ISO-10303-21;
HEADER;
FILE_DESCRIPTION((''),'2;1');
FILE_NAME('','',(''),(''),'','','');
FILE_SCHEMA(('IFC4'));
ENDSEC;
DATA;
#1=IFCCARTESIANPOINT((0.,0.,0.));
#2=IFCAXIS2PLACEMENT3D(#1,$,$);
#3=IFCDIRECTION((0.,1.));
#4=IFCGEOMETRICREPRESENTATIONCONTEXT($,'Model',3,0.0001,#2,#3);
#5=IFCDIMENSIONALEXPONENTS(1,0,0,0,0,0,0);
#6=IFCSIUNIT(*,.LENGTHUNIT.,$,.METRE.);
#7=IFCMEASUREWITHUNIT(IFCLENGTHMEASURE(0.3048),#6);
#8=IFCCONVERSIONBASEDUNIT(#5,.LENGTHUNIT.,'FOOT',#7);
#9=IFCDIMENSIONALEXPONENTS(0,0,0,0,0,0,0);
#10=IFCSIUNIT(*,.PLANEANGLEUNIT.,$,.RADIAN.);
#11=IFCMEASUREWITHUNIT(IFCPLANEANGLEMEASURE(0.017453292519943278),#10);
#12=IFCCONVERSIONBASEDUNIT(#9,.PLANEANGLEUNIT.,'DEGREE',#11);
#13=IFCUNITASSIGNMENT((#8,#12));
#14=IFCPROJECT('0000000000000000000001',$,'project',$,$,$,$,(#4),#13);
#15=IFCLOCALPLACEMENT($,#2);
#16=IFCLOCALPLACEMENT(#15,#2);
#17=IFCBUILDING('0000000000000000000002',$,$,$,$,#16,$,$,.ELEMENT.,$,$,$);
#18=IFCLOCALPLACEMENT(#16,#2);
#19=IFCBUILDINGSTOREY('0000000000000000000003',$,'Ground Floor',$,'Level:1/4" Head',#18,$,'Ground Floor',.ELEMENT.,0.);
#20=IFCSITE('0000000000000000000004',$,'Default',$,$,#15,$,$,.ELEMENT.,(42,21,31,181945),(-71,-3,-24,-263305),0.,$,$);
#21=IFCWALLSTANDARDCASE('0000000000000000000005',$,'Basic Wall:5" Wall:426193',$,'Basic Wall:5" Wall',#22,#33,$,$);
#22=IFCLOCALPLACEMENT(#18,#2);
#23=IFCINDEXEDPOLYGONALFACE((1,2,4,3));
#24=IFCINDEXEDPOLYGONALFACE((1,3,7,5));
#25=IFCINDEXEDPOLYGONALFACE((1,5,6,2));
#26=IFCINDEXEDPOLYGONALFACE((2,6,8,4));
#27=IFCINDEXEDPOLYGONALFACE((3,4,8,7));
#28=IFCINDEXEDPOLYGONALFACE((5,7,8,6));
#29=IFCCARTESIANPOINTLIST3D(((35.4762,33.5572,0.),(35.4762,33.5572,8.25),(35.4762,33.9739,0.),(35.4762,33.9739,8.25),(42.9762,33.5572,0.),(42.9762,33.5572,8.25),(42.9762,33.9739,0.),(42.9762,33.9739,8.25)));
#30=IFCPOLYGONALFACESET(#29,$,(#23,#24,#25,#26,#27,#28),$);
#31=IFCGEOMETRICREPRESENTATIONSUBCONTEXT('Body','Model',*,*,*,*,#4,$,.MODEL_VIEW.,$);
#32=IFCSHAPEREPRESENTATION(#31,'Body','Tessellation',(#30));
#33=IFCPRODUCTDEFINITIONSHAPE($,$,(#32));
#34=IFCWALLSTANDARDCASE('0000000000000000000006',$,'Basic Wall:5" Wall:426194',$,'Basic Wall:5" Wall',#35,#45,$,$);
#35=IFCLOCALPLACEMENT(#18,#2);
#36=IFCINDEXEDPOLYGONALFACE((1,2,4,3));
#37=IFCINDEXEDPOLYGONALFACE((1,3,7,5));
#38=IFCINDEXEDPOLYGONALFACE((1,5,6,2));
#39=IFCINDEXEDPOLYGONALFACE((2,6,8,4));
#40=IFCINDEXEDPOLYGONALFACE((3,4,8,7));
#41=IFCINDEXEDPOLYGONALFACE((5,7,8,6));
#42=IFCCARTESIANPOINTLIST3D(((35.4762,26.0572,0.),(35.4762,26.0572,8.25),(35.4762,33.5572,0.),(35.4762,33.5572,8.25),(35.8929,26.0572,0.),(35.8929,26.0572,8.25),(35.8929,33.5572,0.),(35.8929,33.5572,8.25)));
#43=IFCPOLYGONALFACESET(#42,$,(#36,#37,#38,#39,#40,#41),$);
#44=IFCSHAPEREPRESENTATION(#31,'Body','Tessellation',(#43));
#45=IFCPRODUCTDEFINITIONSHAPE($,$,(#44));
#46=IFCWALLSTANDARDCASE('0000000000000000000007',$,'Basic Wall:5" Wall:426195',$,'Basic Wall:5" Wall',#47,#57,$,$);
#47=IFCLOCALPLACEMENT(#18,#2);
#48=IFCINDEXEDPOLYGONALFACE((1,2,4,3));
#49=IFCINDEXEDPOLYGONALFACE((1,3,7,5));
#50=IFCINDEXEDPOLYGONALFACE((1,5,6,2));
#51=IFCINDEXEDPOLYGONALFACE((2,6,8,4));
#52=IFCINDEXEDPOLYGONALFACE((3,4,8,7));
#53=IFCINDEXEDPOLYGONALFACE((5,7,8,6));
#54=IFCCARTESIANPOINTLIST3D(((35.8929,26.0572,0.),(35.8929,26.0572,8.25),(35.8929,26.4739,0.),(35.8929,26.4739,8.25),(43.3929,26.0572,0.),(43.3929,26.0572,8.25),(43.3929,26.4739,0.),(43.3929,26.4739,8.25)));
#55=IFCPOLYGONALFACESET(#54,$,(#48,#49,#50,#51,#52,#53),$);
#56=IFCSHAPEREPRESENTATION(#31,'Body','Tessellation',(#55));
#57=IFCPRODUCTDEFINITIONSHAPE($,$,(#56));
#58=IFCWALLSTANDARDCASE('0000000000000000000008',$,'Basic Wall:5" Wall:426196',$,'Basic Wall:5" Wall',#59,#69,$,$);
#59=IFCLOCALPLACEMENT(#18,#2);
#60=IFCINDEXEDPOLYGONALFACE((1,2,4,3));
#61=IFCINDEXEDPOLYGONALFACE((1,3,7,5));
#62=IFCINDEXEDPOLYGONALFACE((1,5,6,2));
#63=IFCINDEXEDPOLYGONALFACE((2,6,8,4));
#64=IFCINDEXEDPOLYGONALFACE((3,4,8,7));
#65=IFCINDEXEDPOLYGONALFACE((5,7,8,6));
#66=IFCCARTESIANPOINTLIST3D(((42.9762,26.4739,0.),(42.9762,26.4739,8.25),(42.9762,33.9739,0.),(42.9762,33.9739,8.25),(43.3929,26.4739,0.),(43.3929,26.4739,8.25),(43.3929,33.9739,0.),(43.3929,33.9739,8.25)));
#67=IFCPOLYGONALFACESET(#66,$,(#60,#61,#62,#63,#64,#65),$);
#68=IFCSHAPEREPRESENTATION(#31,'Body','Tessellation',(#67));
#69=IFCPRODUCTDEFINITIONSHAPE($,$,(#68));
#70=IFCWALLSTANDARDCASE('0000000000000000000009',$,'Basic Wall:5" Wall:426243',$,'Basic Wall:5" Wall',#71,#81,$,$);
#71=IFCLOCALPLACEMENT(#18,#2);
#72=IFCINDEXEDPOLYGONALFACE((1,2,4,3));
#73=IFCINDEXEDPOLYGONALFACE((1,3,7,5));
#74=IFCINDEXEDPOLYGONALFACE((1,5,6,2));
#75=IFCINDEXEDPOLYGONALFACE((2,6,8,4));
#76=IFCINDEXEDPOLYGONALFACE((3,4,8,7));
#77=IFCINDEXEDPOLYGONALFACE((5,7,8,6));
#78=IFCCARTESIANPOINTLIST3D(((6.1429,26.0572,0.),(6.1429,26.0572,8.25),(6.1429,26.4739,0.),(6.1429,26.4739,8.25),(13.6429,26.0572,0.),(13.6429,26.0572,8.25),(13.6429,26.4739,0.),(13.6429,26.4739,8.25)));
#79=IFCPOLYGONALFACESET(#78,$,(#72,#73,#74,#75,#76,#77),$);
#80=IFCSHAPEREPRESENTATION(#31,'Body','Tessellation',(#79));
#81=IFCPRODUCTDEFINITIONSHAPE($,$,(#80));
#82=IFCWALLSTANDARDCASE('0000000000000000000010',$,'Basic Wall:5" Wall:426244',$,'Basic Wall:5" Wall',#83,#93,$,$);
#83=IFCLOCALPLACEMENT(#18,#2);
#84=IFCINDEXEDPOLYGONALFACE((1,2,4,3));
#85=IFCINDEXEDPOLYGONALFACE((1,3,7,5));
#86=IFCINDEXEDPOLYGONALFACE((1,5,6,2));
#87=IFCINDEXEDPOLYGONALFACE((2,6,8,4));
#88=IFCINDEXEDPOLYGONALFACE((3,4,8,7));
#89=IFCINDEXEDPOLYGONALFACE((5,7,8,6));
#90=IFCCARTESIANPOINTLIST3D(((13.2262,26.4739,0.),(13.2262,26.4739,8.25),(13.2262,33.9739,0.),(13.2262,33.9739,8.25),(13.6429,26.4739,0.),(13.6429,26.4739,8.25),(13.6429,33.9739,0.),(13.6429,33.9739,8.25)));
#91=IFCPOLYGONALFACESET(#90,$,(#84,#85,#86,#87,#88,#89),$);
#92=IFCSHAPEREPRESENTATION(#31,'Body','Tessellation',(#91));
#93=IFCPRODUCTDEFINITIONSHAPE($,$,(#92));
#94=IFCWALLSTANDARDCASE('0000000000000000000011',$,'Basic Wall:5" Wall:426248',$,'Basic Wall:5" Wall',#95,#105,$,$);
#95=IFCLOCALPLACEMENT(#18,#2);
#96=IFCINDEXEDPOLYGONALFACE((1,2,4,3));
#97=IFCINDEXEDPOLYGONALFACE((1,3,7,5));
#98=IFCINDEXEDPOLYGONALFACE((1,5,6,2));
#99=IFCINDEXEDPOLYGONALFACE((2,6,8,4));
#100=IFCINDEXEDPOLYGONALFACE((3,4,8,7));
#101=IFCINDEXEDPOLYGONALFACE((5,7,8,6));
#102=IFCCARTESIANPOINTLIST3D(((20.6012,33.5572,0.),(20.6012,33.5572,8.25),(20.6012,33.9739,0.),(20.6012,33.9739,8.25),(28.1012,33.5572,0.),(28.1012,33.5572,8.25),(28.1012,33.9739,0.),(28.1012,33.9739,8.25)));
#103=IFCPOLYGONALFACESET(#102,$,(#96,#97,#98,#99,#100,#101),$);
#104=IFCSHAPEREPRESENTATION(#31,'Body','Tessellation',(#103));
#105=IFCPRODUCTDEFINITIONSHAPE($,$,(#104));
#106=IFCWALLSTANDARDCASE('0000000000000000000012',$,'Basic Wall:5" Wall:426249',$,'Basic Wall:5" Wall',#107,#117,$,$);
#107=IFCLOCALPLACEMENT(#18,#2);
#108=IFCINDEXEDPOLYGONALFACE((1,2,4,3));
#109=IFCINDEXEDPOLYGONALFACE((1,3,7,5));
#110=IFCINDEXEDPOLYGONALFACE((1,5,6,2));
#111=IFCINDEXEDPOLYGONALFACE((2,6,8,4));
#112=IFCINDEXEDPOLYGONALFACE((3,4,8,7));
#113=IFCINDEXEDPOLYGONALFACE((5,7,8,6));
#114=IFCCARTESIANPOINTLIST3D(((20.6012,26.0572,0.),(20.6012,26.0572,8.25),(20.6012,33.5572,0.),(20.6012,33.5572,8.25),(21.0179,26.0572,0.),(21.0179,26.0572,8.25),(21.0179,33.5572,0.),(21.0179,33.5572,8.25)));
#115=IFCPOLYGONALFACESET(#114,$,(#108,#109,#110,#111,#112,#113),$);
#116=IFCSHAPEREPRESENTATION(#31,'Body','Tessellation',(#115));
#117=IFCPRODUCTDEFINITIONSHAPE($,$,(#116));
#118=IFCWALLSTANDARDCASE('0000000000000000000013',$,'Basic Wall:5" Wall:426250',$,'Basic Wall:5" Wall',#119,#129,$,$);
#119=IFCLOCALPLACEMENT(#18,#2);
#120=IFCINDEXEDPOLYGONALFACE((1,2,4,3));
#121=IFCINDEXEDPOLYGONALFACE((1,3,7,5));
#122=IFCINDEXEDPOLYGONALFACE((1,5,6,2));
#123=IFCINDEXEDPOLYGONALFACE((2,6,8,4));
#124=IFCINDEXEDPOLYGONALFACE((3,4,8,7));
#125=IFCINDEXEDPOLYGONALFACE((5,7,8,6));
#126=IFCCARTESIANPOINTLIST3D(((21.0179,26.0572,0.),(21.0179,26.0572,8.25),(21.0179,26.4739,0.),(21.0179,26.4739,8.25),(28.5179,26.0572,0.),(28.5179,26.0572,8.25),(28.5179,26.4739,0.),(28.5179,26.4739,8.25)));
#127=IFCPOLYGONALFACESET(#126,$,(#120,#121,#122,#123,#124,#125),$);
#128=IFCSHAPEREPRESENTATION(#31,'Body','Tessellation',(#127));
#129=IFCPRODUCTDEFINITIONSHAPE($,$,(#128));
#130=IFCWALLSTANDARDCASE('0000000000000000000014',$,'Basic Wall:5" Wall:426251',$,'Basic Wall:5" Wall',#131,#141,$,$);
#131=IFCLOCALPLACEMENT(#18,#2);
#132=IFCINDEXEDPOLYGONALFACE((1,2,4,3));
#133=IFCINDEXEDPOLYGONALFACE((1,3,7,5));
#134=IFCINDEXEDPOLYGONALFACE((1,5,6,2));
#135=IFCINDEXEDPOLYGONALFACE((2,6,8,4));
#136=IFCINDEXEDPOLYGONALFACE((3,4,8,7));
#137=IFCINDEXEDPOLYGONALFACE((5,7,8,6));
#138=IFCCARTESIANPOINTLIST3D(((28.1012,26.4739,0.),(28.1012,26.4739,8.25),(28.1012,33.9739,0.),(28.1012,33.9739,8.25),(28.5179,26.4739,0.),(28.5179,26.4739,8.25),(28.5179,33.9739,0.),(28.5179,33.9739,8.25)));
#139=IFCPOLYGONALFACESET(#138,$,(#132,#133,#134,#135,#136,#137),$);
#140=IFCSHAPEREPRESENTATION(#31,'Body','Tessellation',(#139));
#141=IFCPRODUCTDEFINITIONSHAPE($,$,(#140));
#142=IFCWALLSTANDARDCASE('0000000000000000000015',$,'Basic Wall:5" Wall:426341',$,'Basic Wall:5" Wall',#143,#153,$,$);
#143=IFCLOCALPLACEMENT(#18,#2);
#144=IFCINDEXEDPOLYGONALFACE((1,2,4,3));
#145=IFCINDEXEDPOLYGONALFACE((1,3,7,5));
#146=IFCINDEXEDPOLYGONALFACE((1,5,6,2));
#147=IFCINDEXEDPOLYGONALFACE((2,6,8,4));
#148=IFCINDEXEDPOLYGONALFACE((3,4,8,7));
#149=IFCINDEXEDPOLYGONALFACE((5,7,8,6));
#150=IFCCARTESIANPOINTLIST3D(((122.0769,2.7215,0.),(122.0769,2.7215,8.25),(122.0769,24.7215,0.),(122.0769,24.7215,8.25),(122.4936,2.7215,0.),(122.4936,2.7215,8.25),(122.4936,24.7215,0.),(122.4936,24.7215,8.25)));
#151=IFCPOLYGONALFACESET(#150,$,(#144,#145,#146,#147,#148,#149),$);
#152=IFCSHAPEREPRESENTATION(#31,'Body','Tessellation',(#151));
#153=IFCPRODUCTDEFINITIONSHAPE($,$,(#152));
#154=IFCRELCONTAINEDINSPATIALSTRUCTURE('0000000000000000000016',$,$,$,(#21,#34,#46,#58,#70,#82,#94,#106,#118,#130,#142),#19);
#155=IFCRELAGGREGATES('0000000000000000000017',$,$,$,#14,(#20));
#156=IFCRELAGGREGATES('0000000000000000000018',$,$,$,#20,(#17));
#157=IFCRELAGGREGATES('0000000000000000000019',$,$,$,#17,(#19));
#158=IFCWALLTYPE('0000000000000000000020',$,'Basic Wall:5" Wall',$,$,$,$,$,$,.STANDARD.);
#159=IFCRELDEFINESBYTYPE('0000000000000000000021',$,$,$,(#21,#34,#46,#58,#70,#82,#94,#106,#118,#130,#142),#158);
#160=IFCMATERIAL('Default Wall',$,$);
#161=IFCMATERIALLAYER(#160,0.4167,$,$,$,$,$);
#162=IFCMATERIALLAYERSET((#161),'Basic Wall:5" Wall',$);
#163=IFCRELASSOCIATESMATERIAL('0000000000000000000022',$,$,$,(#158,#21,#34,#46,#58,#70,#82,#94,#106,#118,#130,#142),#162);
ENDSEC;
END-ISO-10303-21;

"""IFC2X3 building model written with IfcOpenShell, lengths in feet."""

from ifc_helpers import new_model, entity, si_unit, converted_unit, direction, frame, frame_2d, origin, place, context, subcontext, project, spatial, rectangle, extrude, material, layer, layer_set, layer_usage, type_object, element, save


model = new_model("IFC2X3")

# Units and contexts
model_context = context("Model", 3, precision=0.0001, world=origin(), true_north=direction((0.0, 1.0)))
body_context = subcontext(model_context, "Body", "Model", "MODEL_VIEW")
ifc_project = project(units=[converted_unit("LENGTHUNIT", "FOOT", entity("IfcLengthMeasure", 0.3048), si_unit("LENGTHUNIT", "METRE"), dimensions=[1, 0, 0, 0, 0, 0, 0]), converted_unit("PLANEANGLEUNIT", "DEGREE", entity("IfcPlaneAngleMeasure", 0.017453292519943278), si_unit("PLANEANGLEUNIT", "RADIAN"), dimensions=[0, 0, 0, 0, 0, 0, 0])], contexts=[model_context])

# Site, building, storey
site_placement = place(None, origin())
site = spatial("IfcSite", under=ifc_project, at=site_placement, Name="Default", CompositionType="ELEMENT", RefLatitude=(42, 21, 31, 181945), RefLongitude=(-71, -3, -24, -263305), RefElevation=0.0)
building_placement = place(site_placement, origin())
building = spatial("IfcBuilding", under=site, at=building_placement, CompositionType="ELEMENT")
storey_placement = place(building_placement, origin())
storey = spatial("IfcBuildingStorey", under=building, at=storey_placement, Name="Ground Floor", ObjectType="Level:1/4\" Head", LongName="Ground Floor", CompositionType="ELEMENT", Elevation=0.0)

# Walls
ifc_material = material(Name="Default Wall")
ifc_layer = layer(ifc_material, 0.4167)
ifc_layer_set = layer_set([ifc_layer], Name="Basic Wall:5\" Wall")
ifc_layer_usage_1 = layer_usage(ifc_layer_set, "AXIS2", "NEGATIVE", 0.2083)
wall_type = type_object("IfcWallType", Name="Basic Wall:5\" Wall", PredefinedType="STANDARD", material=ifc_layer_set)
wall_1_placement = place(storey_placement, frame((35.4762, 33.7656, 0.0)))
element("IfcWallStandardCase", 1, at=wall_1_placement, inside=storey, type_object=wall_type, material=ifc_layer_usage_1, Name="Basic Wall:5\" Wall:426193", ObjectType="Basic Wall:5\" Wall", context=body_context, shape_type="SweptSolid", body=[
    extrude(rectangle(XDim=7.5, YDim=0.4167, at=frame_2d((3.75, 0.0), x_axis=(-1.0, 0.0))), origin(), (0.0, 0.0, 1.0), 8.25),
])
wall_2_placement = place(storey_placement, frame((35.6845, 26.0572, 0.0), z_axis=(0.0, 0.0, 1.0), x_axis=(0.0, 1.0, 0.0)))
element("IfcWallStandardCase", 2, at=wall_2_placement, inside=storey, type_object=wall_type, material=ifc_layer_usage_1, Name="Basic Wall:5\" Wall:426194", ObjectType="Basic Wall:5\" Wall", context=body_context, shape_type="SweptSolid", body=[
    extrude(rectangle(XDim=7.5, YDim=0.4167, at=frame_2d((3.75, 0.0), x_axis=(-1.0, 0.0))), origin(), (0.0, 0.0, 1.0), 8.25),
])
wall_3_placement = place(storey_placement, frame((43.3929, 26.2656, 0.0), z_axis=(0.0, 0.0, 1.0), x_axis=(-1.0, 0.0, 0.0)))
element("IfcWallStandardCase", 3, at=wall_3_placement, inside=storey, type_object=wall_type, material=ifc_layer_usage_1, Name="Basic Wall:5\" Wall:426195", ObjectType="Basic Wall:5\" Wall", context=body_context, shape_type="SweptSolid", body=[
    extrude(rectangle(XDim=7.5, YDim=0.4167, at=frame_2d((3.75, 0.0), x_axis=(-1.0, 0.0))), origin(), (0.0, 0.0, 1.0), 8.25),
])
wall_4_placement = place(storey_placement, frame((43.1845, 33.9739, 0.0), z_axis=(0.0, 0.0, 1.0), x_axis=(0.0, -1.0, 0.0)))
element("IfcWallStandardCase", 4, at=wall_4_placement, inside=storey, type_object=wall_type, material=ifc_layer_usage_1, Name="Basic Wall:5\" Wall:426196", ObjectType="Basic Wall:5\" Wall", context=body_context, shape_type="SweptSolid", body=[
    extrude(rectangle(XDim=7.5, YDim=0.4167, at=frame_2d((3.75, 0.0), x_axis=(-1.0, 0.0))), origin(), (0.0, 0.0, 1.0), 8.25),
])
wall_5_placement = place(storey_placement, frame((13.6429, 26.2656, 0.0), z_axis=(0.0, 0.0, 1.0), x_axis=(-1.0, 0.0, 0.0)))
element("IfcWallStandardCase", 5, at=wall_5_placement, inside=storey, type_object=wall_type, material=ifc_layer_usage_1, Name="Basic Wall:5\" Wall:426243", ObjectType="Basic Wall:5\" Wall", context=body_context, shape_type="SweptSolid", body=[
    extrude(rectangle(XDim=7.5, YDim=0.4167, at=frame_2d((3.75, 0.0), x_axis=(-1.0, 0.0))), origin(), (0.0, 0.0, 1.0), 8.25),
])
wall_6_placement = place(storey_placement, frame((13.4345, 33.9739, 0.0), z_axis=(0.0, 0.0, 1.0), x_axis=(0.0, -1.0, 0.0)))
element("IfcWallStandardCase", 6, at=wall_6_placement, inside=storey, type_object=wall_type, material=ifc_layer_usage_1, Name="Basic Wall:5\" Wall:426244", ObjectType="Basic Wall:5\" Wall", context=body_context, shape_type="SweptSolid", body=[
    extrude(rectangle(XDim=7.5, YDim=0.4167, at=frame_2d((3.75, 0.0), x_axis=(-1.0, 0.0))), origin(), (0.0, 0.0, 1.0), 8.25),
])
wall_7_placement = place(storey_placement, frame((20.6012, 33.7656, 0.0)))
element("IfcWallStandardCase", 7, at=wall_7_placement, inside=storey, type_object=wall_type, material=ifc_layer_usage_1, Name="Basic Wall:5\" Wall:426248", ObjectType="Basic Wall:5\" Wall", context=body_context, shape_type="SweptSolid", body=[
    extrude(rectangle(XDim=7.5, YDim=0.4167, at=frame_2d((3.75, 0.0), x_axis=(-1.0, 0.0))), origin(), (0.0, 0.0, 1.0), 8.25),
])
wall_8_placement = place(storey_placement, frame((20.8095, 26.0572, 0.0), z_axis=(0.0, 0.0, 1.0), x_axis=(0.0, 1.0, 0.0)))
element("IfcWallStandardCase", 8, at=wall_8_placement, inside=storey, type_object=wall_type, material=ifc_layer_usage_1, Name="Basic Wall:5\" Wall:426249", ObjectType="Basic Wall:5\" Wall", context=body_context, shape_type="SweptSolid", body=[
    extrude(rectangle(XDim=7.5, YDim=0.4167, at=frame_2d((3.75, 0.0), x_axis=(-1.0, 0.0))), origin(), (0.0, 0.0, 1.0), 8.25),
])
wall_9_placement = place(storey_placement, frame((28.5179, 26.2656, 0.0), z_axis=(0.0, 0.0, 1.0), x_axis=(-1.0, 0.0, 0.0)))
element("IfcWallStandardCase", 9, at=wall_9_placement, inside=storey, type_object=wall_type, material=ifc_layer_usage_1, Name="Basic Wall:5\" Wall:426250", ObjectType="Basic Wall:5\" Wall", context=body_context, shape_type="SweptSolid", body=[
    extrude(rectangle(XDim=7.5, YDim=0.4167, at=frame_2d((3.75, 0.0), x_axis=(-1.0, 0.0))), origin(), (0.0, 0.0, 1.0), 8.25),
])
wall_10_placement = place(storey_placement, frame((28.3095, 33.9739, 0.0), z_axis=(0.0, 0.0, 1.0), x_axis=(0.0, -1.0, 0.0)))
element("IfcWallStandardCase", 10, at=wall_10_placement, inside=storey, type_object=wall_type, material=ifc_layer_usage_1, Name="Basic Wall:5\" Wall:426251", ObjectType="Basic Wall:5\" Wall", context=body_context, shape_type="SweptSolid", body=[
    extrude(rectangle(XDim=7.5, YDim=0.4167, at=frame_2d((3.75, 0.0), x_axis=(-1.0, 0.0))), origin(), (0.0, 0.0, 1.0), 8.25),
])
wall_11_placement = place(storey_placement, frame((122.2852, 24.7215, 0.0), z_axis=(0.0, 0.0, 1.0), x_axis=(0.0, -1.0, 0.0)))
element("IfcWallStandardCase", 11, at=wall_11_placement, inside=storey, type_object=wall_type, material=ifc_layer_usage_1, Name="Basic Wall:5\" Wall:426341", ObjectType="Basic Wall:5\" Wall", context=body_context, shape_type="SweptSolid", body=[
    extrude(rectangle(XDim=22.0, YDim=0.4167, at=frame_2d((11.0, 0.0), x_axis=(-1.0, 0.0))), origin(), (0.0, 0.0, 1.0), 8.25),
])

save(model, "model.ifc")
